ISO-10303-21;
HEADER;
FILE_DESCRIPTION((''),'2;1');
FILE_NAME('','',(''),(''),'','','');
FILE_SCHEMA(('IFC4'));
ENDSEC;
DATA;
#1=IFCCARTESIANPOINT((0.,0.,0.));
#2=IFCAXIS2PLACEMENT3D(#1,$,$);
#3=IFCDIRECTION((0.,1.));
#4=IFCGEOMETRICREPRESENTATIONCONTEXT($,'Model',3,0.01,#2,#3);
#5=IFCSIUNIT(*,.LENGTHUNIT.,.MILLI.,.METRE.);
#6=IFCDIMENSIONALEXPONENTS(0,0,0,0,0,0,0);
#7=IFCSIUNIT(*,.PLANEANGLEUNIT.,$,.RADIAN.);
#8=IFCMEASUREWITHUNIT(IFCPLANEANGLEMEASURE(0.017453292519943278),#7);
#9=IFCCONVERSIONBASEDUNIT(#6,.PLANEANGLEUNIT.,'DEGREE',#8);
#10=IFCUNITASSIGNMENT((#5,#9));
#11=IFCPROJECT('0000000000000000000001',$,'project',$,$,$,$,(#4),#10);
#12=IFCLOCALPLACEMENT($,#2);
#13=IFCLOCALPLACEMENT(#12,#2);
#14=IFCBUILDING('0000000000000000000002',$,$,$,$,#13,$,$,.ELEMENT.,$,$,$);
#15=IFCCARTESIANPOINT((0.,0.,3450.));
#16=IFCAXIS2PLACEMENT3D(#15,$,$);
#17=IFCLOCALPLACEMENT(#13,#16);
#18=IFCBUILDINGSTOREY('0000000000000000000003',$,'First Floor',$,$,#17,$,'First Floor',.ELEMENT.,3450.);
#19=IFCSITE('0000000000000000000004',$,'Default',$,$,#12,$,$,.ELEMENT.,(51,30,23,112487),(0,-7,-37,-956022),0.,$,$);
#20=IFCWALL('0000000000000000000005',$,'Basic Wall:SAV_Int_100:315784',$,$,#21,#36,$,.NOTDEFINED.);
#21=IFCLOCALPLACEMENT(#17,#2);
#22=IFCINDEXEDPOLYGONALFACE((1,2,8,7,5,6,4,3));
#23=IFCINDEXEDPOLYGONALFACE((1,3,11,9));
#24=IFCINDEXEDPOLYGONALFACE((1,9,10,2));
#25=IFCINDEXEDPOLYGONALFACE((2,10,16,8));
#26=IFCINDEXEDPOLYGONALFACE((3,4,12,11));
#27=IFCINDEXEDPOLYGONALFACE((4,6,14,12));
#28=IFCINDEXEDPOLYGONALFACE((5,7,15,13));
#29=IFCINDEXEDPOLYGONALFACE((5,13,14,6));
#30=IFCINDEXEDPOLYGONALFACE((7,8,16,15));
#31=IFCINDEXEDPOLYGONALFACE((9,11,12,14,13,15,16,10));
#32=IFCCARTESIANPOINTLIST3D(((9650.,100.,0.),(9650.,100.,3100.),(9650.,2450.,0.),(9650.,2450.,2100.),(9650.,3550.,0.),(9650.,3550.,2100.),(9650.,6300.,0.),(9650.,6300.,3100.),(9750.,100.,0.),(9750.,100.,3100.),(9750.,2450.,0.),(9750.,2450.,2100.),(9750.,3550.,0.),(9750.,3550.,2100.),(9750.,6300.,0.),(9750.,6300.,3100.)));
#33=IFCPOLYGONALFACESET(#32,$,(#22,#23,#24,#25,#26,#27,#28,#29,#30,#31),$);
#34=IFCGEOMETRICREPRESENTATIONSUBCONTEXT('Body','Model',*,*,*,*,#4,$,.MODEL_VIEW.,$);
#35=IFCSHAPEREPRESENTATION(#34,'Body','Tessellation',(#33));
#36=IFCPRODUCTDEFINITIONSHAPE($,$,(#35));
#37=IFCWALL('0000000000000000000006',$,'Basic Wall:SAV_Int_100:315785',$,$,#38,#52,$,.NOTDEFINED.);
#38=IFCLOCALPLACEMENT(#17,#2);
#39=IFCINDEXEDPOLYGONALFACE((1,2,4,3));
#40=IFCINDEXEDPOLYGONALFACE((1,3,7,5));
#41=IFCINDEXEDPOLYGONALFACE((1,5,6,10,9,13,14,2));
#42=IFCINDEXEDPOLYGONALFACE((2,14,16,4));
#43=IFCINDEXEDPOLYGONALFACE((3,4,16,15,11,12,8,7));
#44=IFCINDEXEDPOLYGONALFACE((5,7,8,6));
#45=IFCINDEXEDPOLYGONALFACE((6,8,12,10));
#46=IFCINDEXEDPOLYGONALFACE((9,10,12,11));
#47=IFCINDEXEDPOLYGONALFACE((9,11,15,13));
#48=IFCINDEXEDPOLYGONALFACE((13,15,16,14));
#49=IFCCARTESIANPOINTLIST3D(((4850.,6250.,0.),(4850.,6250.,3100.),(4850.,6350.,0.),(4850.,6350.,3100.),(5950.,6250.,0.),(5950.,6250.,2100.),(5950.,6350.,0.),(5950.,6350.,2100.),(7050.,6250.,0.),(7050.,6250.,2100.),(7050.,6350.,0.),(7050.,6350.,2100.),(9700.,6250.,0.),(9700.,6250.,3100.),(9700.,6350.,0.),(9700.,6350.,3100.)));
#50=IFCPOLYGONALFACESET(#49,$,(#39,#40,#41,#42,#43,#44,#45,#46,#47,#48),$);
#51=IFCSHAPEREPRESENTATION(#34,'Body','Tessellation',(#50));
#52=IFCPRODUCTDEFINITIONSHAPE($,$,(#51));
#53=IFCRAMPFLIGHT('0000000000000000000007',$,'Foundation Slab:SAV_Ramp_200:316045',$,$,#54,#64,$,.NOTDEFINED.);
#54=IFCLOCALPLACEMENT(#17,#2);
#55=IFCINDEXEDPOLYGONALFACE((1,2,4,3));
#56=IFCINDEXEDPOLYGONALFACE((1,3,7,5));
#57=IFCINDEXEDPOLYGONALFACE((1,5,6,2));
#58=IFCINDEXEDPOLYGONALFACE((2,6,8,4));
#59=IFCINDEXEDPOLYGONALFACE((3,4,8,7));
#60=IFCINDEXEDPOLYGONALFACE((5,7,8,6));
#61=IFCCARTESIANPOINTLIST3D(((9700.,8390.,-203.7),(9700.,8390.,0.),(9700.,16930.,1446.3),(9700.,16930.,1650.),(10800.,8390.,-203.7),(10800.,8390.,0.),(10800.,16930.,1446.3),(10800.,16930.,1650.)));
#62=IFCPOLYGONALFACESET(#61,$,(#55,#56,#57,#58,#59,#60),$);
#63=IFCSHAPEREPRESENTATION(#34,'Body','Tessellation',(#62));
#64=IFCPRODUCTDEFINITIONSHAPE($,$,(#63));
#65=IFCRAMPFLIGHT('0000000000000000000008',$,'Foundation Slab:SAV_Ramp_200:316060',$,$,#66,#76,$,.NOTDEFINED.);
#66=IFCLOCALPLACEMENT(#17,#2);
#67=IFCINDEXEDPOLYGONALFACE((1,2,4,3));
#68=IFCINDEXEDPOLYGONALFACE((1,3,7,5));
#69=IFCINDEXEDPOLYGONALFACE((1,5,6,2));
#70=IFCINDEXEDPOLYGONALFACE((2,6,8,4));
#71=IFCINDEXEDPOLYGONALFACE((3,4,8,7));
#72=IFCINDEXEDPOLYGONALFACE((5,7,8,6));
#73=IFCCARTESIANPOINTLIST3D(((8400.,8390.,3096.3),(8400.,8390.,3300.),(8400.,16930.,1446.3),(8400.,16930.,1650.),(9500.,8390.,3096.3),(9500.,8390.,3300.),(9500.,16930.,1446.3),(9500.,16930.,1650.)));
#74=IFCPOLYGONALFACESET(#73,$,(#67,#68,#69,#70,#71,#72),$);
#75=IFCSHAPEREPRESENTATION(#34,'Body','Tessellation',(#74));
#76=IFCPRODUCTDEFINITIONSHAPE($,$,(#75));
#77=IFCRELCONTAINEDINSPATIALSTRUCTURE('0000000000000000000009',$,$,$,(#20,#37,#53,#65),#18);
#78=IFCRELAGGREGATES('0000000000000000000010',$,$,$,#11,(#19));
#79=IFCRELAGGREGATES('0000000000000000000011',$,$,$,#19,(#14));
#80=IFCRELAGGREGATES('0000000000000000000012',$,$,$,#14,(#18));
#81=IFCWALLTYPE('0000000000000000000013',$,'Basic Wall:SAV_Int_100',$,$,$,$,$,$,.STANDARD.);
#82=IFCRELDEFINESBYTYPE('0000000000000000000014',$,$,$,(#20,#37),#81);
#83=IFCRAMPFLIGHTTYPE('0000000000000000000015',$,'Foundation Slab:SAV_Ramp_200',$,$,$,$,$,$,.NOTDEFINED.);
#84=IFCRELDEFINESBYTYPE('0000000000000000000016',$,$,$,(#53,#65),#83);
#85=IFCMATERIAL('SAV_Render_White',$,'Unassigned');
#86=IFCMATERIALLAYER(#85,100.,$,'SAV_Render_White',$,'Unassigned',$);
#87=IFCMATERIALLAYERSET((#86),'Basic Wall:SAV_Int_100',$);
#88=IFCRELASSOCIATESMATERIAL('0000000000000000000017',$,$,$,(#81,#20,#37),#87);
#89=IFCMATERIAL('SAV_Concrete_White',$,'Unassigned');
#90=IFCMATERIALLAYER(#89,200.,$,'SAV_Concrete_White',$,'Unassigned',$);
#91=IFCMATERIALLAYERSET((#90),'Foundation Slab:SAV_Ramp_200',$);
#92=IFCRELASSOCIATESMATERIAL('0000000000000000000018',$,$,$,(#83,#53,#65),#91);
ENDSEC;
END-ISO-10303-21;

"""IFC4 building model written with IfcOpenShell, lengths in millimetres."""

from ifc_helpers import new_model, entity, si_unit, converted_unit, direction, frame, frame_2d, origin, place, context, subcontext, project, spatial, rectangle, extrude, clip, halfspace, material, layer, layer_set, layer_usage, type_object, element, save


model = new_model("IFC4")

# Units and contexts
model_context = context("Model", 3, precision=0.01, world=origin(), true_north=direction((0.0, 1.0)))
body_context = subcontext(model_context, "Body", "Model", "MODEL_VIEW")
ifc_project = project(units=[si_unit("LENGTHUNIT", "METRE", prefix="MILLI"), converted_unit("PLANEANGLEUNIT", "DEGREE", entity("IfcPlaneAngleMeasure", 0.017453292519943278), si_unit("PLANEANGLEUNIT", "RADIAN"), dimensions=[0, 0, 0, 0, 0, 0, 0])], contexts=[model_context])

# Site, building, storey
site_placement = place(None, origin())
site = spatial("IfcSite", under=ifc_project, at=site_placement, Name="Default", CompositionType="ELEMENT", RefLatitude=(51, 30, 23, 112487), RefLongitude=(0, -7, -37, -956022), RefElevation=0.0)
building_placement = place(site_placement, origin())
building = spatial("IfcBuilding", under=site, at=building_placement, CompositionType="ELEMENT")
storey_placement = place(building_placement, frame((0.0, 0.0, 3450.0)))
storey = spatial("IfcBuildingStorey", under=building, at=storey_placement, Name="First Floor", LongName="First Floor", CompositionType="ELEMENT", Elevation=3450.0)

# Shared definitions
ifc_material_1 = material(Name="SAV_Concrete_White", Category="Unassigned")

# Shared definitions
ifc_layer_1 = layer(ifc_material_1, 200.0, Name="SAV_Concrete_White", Category="Unassigned")
ifc_layer_set_1 = layer_set([ifc_layer_1], Name="Foundation Slab:SAV_Ramp_200")

# Shared definitions
ifc_material_2 = material(Name="SAV_Render_White", Category="Unassigned")

# Shared definitions
ifc_layer_2 = layer(ifc_material_2, 100.0, Name="SAV_Render_White", Category="Unassigned")
ifc_layer_set_2 = layer_set([ifc_layer_2], Name="Basic Wall:SAV_Int_100")
wall_type_1 = type_object("IfcWallType", Name="Basic Wall:SAV_Int_100", PredefinedType="STANDARD", material=ifc_layer_set_2)

# Walls, openings
ifc_layer_usage_1 = layer_usage(ifc_layer_set_2, "AXIS2", "NEGATIVE", 50.0)
wall_1_placement = place(storey_placement, frame((9700.0, 100.0, 0.0), z_axis=(0.0, 0.0, 1.0), x_axis=(0.0, 1.0, 0.0)))
wall_1 = element("IfcWall", 1, at=wall_1_placement, inside=storey, type_object=wall_type_1, material=ifc_layer_usage_1, Name="Basic Wall:SAV_Int_100:315784", PredefinedType="NOTDEFINED", context=body_context, shape_type="SweptSolid", body=[
    extrude(rectangle(XDim=6200.0, YDim=100.0, at=frame_2d((3100.0, 0.0), x_axis=(1.0, 0.0))), origin(), (0.0, 0.0, 1.0), 3100.0),
])
opening_1_placement = place(wall_1_placement, frame((2350.0, -50.0, 0.0)))
element("IfcOpeningElement", 2, at=opening_1_placement, cuts=wall_1, PredefinedType="OPENING", context=body_context, shape_type="SweptSolid", body=[
    extrude(rectangle(XDim=2100.0, YDim=1100.0, at=frame_2d((1050.0, 550.0), x_axis=(1.0, 0.0))), frame((0.0, 0.0, 0.0), z_axis=(0.0, 1.0, 0.0), x_axis=(0.0, 0.0, 1.0)), (0.0, 0.0, 1.0), 100.0),
])
ifc_layer_usage_2 = layer_usage(ifc_layer_set_2, "AXIS2", "NEGATIVE", 50.0)
wall_2_placement = place(storey_placement, frame((4850.0, 6300.0, 0.0)))
wall_2 = element("IfcWall", 3, at=wall_2_placement, inside=storey, type_object=wall_type_1, material=ifc_layer_usage_2, Name="Basic Wall:SAV_Int_100:315785", PredefinedType="NOTDEFINED", context=body_context, shape_type="SweptSolid", body=[
    extrude(rectangle(XDim=4850.0, YDim=100.0, at=frame_2d((2425.0, 0.0), x_axis=(-1.0, 0.0))), origin(), (0.0, 0.0, 1.0), 3100.0),
])
opening_2_placement = place(wall_2_placement, frame((1100.0, -50.0, 0.0)))
element("IfcOpeningElement", 4, at=opening_2_placement, cuts=wall_2, PredefinedType="OPENING", context=body_context, shape_type="SweptSolid", body=[
    extrude(rectangle(XDim=2100.0, YDim=1100.0, at=frame_2d((1050.0, 550.0), x_axis=(1.0, 0.0))), frame((0.0, 0.0, 0.0), z_axis=(0.0, 1.0, 0.0), x_axis=(0.0, 0.0, 1.0)), (0.0, 0.0, 1.0), 100.0),
])

# Ramp flights
ifc_layer_usage_3 = layer_usage(ifc_layer_set_1, "AXIS3", "POSITIVE", 0.0)
ramp_flight_type = type_object("IfcRampFlightType", Name="Foundation Slab:SAV_Ramp_200", PredefinedType="NOTDEFINED", material=ifc_layer_set_1)
ramp_flight_1_placement = place(storey_placement, origin())
element("IfcRampFlight", 5, at=ramp_flight_1_placement, inside=storey, type_object=ramp_flight_type, material=ifc_layer_usage_3, Name="Foundation Slab:SAV_Ramp_200:316045", PredefinedType="NOTDEFINED", context=body_context, shape_type="Clipping", body=[
    clip(clip(extrude(rectangle(XDim=8697.9, YDim=1100.0, at=frame_2d((0.0, 0.0), x_axis=(1.0, 0.0))), frame((10250.0, 12660.0, 825.0), z_axis=(0.0, 0.1897, -0.981842), x_axis=(0.0, 0.981842, 0.1897)), (-0.1897, 0.0, 0.981842), 207.5), halfspace(frame((10250.0, 8390.0, -203.7), z_axis=(0.0, 0.1897, -0.981842), x_axis=(0.0, 0.981842, 0.1897)), False)), halfspace(frame((10250.0, 8390.0, 0.0), z_axis=(0.0, -0.1897, 0.981842), x_axis=(0.0, -0.981842, -0.1897)), False)),
])
ifc_layer_usage_4 = layer_usage(ifc_layer_set_1, "AXIS3", "POSITIVE", 0.0)
ramp_flight_2_placement = place(storey_placement, origin())
element("IfcRampFlight", 6, at=ramp_flight_2_placement, inside=storey, type_object=ramp_flight_type, material=ifc_layer_usage_4, Name="Foundation Slab:SAV_Ramp_200:316060", PredefinedType="NOTDEFINED", context=body_context, shape_type="Clipping", body=[
    clip(clip(extrude(rectangle(XDim=8697.9, YDim=1100.0, at=frame_2d((0.0, 0.0), x_axis=(1.0, 0.0))), frame((8950.0, 12660.0, 2475.0), z_axis=(0.0, -0.1897, -0.981842), x_axis=(0.0, 0.981842, -0.1897)), (0.1897, 0.0, 0.981842), 207.5), halfspace(frame((8950.0, 16930.0, 1446.3), z_axis=(0.0, -0.1897, -0.981842), x_axis=(0.0, -0.981842, 0.1897)), False)), halfspace(frame((8950.0, 16930.0, 1650.0), z_axis=(0.0, 0.1897, 0.981842), x_axis=(0.0, 0.981842, -0.1897)), False)),
])

save(model, "model.ifc")
